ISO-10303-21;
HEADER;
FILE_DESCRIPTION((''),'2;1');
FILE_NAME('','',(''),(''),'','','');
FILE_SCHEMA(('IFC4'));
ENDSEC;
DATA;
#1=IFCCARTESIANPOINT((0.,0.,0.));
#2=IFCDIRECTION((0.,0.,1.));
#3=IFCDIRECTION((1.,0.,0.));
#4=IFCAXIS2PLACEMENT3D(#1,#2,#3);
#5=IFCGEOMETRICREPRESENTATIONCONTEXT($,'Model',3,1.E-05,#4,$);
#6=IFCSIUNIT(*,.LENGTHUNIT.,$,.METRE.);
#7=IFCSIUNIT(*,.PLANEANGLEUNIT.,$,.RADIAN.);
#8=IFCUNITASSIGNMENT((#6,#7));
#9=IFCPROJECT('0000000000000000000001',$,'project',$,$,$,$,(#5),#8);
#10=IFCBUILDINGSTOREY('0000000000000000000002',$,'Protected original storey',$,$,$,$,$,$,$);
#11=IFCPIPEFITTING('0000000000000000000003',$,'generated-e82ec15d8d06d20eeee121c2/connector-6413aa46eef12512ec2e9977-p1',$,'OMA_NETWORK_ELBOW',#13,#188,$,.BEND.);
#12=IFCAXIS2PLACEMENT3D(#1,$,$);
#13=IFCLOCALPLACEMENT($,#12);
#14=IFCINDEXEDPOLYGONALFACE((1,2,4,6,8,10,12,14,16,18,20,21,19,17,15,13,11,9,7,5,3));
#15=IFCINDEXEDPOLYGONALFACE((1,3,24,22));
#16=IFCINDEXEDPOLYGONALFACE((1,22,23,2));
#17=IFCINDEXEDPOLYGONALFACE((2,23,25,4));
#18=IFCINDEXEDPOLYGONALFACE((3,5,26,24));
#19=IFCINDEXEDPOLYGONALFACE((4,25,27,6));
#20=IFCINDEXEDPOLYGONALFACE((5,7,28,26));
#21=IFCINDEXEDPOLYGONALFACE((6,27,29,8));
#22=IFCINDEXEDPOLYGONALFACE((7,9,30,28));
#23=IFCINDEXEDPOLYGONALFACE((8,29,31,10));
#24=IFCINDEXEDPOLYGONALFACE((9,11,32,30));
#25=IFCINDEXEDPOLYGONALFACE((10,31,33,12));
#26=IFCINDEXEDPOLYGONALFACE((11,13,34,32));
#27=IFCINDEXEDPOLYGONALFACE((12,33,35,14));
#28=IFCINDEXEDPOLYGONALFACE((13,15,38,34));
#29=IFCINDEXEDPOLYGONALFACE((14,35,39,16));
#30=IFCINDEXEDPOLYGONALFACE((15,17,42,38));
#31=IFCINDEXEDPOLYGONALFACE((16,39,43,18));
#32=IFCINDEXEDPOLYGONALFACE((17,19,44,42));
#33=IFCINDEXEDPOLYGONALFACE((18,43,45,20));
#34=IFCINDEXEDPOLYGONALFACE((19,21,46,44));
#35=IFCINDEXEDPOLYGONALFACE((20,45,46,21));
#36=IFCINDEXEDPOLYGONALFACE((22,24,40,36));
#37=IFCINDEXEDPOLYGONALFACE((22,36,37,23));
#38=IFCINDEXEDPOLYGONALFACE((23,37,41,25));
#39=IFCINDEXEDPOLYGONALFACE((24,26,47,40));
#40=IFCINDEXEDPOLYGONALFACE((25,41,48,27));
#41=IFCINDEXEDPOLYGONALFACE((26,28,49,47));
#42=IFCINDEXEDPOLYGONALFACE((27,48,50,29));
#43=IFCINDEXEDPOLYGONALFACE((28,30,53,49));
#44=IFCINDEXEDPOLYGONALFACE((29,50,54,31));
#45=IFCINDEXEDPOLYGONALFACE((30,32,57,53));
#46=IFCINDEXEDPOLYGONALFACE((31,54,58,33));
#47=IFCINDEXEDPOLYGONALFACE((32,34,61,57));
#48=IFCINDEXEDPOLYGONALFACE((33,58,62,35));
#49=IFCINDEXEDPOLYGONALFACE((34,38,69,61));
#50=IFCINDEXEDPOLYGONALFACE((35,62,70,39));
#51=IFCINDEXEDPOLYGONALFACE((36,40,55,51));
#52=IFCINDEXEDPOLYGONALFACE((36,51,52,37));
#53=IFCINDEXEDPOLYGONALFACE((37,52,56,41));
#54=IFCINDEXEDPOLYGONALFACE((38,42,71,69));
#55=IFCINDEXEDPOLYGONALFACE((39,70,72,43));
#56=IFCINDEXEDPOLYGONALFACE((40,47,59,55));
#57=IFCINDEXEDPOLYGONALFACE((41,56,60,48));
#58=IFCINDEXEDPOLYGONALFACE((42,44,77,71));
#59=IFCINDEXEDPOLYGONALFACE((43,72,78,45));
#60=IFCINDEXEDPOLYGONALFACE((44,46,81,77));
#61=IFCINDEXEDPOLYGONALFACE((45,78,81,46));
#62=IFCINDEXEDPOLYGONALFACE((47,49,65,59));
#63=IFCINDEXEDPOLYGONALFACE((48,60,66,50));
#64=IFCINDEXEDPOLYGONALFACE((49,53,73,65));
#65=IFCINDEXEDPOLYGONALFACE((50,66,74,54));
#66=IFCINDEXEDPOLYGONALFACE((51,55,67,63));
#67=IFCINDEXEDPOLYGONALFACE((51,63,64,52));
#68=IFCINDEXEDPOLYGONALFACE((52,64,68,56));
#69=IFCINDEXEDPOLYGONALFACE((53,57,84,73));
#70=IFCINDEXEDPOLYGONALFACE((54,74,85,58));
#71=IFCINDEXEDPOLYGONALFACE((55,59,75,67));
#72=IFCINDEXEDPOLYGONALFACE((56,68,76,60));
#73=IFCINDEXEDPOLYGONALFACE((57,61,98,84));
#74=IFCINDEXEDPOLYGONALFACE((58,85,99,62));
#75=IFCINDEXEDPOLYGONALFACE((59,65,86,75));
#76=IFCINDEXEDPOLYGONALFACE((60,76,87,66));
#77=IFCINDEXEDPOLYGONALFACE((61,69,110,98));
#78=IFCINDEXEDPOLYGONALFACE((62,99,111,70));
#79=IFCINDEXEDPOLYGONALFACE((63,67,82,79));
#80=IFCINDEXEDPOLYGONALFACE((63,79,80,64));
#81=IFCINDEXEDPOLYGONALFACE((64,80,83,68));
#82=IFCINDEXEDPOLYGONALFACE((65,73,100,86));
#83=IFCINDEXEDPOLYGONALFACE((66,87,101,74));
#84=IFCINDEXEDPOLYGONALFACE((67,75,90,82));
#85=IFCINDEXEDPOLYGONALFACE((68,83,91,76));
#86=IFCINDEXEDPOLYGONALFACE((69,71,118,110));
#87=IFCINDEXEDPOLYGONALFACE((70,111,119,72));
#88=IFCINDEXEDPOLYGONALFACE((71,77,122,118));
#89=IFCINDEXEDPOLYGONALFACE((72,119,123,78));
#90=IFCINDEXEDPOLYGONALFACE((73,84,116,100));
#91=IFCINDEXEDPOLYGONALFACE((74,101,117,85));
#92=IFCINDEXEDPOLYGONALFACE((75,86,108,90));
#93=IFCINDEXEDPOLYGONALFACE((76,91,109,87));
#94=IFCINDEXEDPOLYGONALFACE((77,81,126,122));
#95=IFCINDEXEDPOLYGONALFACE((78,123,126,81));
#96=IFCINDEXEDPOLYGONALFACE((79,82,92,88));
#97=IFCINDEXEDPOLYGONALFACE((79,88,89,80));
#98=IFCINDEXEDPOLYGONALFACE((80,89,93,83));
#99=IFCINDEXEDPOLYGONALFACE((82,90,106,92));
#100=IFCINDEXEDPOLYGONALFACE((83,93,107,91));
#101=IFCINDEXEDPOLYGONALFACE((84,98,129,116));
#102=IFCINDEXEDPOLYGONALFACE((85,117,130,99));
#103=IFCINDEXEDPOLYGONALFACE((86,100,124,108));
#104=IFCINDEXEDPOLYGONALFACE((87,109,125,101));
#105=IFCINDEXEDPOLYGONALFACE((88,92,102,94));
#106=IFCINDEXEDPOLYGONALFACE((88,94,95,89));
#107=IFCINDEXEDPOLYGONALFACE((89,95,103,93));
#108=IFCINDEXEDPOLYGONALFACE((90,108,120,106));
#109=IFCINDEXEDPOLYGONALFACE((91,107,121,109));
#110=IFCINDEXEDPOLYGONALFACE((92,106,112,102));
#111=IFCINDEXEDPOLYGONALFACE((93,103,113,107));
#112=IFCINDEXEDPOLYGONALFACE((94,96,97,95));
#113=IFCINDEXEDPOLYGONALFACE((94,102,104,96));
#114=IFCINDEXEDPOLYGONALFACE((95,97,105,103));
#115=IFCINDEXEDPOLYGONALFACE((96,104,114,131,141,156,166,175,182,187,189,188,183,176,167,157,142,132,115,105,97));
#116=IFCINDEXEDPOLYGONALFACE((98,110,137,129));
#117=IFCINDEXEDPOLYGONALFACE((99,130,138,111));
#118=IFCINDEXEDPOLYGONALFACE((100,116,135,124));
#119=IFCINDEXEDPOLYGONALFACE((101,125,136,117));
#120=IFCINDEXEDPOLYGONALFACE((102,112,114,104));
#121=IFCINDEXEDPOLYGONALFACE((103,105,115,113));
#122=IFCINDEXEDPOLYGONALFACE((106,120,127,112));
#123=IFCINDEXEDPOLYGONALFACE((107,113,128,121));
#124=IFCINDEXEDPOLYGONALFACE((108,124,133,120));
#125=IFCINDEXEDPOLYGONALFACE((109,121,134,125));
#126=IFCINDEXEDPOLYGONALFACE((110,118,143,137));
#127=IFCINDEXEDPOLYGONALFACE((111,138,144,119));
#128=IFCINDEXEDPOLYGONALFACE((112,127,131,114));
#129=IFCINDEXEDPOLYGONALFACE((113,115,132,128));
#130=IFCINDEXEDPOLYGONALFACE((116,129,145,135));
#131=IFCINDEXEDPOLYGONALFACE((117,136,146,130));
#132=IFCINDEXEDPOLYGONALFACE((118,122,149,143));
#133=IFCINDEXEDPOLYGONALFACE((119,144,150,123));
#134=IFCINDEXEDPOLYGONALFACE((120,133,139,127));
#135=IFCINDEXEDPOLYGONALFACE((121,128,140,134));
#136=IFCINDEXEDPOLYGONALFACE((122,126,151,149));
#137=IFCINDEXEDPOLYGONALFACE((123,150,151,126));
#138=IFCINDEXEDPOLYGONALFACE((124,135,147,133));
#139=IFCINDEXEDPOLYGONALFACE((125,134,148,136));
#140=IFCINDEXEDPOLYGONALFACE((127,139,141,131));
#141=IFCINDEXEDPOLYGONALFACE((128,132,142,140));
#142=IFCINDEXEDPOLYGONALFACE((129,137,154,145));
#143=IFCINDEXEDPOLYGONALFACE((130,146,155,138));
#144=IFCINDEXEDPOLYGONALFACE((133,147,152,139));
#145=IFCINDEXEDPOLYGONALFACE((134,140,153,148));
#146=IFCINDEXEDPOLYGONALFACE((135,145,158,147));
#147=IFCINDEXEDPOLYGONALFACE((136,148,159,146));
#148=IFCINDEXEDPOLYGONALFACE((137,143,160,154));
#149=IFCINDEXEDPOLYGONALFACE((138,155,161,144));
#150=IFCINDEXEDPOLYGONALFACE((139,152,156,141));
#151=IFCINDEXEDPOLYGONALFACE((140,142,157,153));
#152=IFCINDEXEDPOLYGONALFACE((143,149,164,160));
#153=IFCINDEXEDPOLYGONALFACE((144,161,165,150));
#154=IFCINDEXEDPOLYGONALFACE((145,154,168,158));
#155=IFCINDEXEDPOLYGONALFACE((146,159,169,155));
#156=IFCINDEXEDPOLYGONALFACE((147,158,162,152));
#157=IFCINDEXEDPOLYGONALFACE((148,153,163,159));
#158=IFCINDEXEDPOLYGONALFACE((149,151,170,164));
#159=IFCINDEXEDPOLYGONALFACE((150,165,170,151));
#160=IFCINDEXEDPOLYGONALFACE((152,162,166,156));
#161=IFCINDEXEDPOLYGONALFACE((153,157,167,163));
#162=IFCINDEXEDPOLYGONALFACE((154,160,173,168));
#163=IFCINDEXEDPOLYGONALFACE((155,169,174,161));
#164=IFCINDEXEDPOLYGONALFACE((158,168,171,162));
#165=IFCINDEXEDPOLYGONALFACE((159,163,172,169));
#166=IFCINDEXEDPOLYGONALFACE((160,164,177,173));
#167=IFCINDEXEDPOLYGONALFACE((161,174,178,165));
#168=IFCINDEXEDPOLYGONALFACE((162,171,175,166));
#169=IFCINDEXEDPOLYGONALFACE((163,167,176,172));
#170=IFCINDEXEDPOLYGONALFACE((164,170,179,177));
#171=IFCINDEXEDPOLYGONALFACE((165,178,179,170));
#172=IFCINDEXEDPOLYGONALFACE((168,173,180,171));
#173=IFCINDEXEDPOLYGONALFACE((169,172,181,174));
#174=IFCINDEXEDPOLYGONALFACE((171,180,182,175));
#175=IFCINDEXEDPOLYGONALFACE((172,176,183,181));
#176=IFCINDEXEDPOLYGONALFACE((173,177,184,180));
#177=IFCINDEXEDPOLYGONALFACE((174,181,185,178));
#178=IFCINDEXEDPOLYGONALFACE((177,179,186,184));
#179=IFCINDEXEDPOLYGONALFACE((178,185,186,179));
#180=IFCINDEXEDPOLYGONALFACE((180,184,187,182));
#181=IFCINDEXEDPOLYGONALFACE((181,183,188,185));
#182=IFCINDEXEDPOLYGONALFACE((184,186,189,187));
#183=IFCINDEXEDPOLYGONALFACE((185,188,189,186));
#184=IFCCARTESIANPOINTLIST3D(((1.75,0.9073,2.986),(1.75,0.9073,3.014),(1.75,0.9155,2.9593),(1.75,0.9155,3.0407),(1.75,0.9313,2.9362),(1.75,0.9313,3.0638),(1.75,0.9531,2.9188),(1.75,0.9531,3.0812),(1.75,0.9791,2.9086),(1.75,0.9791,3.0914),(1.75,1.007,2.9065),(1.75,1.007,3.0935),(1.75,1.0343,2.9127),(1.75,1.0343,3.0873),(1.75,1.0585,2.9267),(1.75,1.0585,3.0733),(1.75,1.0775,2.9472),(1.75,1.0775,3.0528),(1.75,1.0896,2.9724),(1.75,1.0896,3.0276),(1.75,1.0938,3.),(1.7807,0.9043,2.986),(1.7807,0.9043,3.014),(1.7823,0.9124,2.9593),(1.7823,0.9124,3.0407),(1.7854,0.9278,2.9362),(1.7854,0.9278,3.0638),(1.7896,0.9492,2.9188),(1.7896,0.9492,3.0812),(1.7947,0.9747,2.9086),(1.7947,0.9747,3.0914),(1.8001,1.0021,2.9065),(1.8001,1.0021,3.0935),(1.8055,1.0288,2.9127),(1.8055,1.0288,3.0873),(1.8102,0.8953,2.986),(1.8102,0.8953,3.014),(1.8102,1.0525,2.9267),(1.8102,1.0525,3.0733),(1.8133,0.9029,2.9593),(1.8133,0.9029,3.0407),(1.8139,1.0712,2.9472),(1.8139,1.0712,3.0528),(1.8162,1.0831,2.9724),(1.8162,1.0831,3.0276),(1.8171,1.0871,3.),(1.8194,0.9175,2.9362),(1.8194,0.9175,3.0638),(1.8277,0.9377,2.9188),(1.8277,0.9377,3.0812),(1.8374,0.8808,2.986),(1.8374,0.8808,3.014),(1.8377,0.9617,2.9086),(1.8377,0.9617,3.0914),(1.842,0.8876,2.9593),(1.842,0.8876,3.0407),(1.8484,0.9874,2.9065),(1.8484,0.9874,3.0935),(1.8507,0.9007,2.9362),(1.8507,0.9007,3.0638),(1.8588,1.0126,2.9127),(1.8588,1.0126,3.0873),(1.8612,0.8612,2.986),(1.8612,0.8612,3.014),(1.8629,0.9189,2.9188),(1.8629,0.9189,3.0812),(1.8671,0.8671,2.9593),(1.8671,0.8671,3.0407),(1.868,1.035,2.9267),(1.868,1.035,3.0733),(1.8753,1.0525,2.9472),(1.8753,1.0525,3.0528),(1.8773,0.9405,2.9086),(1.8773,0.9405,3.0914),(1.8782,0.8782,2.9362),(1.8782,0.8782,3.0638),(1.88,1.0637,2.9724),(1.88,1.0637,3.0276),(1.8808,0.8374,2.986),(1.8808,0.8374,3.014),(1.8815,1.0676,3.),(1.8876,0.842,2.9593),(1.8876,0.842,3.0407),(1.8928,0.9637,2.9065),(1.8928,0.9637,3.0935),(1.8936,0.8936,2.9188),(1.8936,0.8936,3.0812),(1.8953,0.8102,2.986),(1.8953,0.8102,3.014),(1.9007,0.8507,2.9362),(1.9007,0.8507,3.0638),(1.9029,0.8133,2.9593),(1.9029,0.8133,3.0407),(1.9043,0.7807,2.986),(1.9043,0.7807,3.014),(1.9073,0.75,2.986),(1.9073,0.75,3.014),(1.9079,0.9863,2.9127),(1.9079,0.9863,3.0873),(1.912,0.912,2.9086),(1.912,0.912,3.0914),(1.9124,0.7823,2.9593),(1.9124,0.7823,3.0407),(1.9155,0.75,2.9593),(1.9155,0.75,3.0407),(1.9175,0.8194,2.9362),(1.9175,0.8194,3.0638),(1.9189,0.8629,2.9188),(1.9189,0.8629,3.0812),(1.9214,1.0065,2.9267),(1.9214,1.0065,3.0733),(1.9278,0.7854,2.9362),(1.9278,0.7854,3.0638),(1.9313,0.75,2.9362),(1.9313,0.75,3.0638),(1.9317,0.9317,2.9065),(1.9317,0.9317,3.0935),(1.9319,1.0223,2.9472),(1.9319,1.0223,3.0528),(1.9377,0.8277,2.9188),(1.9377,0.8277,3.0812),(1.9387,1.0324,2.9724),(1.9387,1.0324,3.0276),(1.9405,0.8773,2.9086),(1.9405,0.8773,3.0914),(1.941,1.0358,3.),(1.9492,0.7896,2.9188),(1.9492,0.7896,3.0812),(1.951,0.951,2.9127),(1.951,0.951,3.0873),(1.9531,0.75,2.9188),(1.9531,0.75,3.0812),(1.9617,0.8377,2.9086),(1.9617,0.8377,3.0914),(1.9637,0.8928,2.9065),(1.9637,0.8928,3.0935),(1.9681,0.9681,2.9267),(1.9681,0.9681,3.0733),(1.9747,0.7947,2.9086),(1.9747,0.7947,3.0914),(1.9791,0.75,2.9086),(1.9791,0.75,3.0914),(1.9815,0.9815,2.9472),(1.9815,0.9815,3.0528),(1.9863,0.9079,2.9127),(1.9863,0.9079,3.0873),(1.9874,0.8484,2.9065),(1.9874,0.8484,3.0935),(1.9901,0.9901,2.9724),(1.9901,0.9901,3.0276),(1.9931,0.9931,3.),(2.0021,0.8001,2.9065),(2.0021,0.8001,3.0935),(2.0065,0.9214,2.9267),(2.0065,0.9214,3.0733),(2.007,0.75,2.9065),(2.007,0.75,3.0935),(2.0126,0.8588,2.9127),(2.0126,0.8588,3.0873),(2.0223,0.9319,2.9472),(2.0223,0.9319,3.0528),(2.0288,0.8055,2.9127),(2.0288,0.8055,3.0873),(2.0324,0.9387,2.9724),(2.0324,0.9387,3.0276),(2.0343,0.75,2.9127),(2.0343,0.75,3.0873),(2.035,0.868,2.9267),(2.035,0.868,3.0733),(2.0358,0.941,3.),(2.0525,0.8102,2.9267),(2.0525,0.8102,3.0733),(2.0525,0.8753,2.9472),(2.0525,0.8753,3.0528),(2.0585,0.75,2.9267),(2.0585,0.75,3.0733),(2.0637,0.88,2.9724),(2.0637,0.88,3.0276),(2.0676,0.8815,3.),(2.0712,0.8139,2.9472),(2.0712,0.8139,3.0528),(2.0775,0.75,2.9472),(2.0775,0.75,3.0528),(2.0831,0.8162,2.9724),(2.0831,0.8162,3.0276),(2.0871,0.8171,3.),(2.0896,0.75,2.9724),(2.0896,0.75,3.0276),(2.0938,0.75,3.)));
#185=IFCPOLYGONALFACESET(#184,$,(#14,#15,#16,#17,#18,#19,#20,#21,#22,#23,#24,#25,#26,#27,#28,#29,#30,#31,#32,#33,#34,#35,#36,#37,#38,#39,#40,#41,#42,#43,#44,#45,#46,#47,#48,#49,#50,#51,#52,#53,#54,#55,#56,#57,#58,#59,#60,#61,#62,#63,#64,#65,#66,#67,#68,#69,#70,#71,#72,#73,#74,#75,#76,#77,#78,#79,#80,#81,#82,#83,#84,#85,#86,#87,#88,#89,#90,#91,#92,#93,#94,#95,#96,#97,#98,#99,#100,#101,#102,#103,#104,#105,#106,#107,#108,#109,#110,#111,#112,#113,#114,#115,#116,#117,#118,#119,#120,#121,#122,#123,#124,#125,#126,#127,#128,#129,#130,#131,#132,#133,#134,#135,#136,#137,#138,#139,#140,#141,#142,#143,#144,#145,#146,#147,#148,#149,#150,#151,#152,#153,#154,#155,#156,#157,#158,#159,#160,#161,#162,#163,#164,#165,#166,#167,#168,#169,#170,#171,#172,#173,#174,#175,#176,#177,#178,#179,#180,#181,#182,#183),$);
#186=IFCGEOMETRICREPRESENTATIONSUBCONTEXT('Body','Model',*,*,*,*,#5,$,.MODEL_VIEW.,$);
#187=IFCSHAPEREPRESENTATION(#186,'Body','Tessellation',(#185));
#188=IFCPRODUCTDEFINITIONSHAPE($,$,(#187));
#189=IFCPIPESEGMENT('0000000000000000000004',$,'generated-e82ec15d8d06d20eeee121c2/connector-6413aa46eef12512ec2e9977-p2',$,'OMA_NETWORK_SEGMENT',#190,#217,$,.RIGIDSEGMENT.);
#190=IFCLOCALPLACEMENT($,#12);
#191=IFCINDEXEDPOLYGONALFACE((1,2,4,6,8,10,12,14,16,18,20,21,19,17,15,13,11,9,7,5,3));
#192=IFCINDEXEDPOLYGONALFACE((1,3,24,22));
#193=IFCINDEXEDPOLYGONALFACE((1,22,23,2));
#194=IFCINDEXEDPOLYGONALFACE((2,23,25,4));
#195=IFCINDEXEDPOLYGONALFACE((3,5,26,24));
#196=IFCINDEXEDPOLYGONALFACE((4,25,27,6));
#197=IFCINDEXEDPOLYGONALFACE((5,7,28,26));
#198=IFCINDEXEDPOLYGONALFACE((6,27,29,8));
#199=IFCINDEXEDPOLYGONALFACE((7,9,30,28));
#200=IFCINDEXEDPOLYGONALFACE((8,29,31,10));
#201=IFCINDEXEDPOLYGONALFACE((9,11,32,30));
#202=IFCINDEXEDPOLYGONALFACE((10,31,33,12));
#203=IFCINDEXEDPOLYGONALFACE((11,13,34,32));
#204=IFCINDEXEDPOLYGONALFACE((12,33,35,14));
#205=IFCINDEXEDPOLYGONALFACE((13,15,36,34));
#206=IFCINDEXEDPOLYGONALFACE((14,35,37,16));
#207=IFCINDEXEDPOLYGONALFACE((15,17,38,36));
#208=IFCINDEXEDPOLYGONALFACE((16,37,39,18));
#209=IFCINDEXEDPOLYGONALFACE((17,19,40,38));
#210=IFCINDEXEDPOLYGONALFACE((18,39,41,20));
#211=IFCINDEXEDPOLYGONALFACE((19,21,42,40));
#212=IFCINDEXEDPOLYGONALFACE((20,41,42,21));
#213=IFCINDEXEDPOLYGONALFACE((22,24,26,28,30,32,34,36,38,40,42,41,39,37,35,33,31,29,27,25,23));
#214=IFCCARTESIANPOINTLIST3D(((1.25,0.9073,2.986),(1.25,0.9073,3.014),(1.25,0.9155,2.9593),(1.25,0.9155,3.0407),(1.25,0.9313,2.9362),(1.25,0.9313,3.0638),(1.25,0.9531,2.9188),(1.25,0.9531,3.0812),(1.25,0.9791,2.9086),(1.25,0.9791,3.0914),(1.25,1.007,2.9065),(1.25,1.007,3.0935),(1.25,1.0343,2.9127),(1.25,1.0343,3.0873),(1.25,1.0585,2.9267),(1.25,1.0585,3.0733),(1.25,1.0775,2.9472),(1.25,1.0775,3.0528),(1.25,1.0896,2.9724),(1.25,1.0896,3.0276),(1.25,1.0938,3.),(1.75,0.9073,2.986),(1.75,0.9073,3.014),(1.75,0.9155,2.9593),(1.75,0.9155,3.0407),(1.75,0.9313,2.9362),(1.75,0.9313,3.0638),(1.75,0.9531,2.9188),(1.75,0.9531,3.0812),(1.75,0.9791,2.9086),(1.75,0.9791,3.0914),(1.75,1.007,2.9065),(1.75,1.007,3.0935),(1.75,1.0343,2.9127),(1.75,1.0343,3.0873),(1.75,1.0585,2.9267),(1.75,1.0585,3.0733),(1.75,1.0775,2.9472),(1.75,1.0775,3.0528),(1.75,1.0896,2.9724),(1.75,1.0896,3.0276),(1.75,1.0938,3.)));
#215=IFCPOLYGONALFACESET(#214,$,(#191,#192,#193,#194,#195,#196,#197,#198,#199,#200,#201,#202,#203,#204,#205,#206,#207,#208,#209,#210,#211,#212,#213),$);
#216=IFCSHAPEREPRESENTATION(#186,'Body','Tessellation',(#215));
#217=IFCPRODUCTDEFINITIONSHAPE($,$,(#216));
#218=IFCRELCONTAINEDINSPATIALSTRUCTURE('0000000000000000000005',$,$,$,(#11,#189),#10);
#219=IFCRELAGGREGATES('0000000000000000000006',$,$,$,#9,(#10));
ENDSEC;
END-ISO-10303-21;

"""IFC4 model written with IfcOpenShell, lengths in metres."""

from ifc_helpers import new_model, entity, si_unit, frame, origin_with_axes, origin_2d, place, context, subcontext, project, spatial, circle, extrude, element, save


model = new_model("IFC4")

# Units and contexts
model_context = context("Model", 3, precision=1e-05, world=origin_with_axes())
body_context = subcontext(model_context, "Body", "Model", "MODEL_VIEW")
ifc_project = project(units=[si_unit("LENGTHUNIT", "METRE"), si_unit("PLANEANGLEUNIT", "RADIAN")], contexts=[model_context])

# Storey
storey = spatial("IfcBuildingStorey", under=ifc_project, Name="Protected original storey")

# Pipe fitting
pipe_fitting_1_placement = place(None, origin_with_axes())
element("IfcPipeFitting", 1, at=pipe_fitting_1_placement, inside=storey, Name="generated-e82ec15d8d06d20eeee121c2/connector-6413aa46eef12512ec2e9977-p1", ObjectType="OMA_NETWORK_ELBOW", PredefinedType="BEND", context=body_context, shape_type="SweptSolid", body=[
    entity("IfcRevolvedAreaSolid", entity("IfcCircleProfileDef", "AREA", None, entity("IfcAxis2Placement2D", entity("IfcCartesianPoint", [0.25, 0.0])), 0.0938), entity("IfcAxis2Placement3D", entity("IfcCartesianPoint", [1.75, 0.75, 3.0]), entity("IfcDirection", [0.0, 1.0, 0.0]), entity("IfcDirection", [1.0, 0.0, 0.0])), entity("IfcAxis1Placement", entity("IfcCartesianPoint", [0.0, 0.0, 0.0]), entity("IfcDirection", [0.0, -1.0, 0.0])), 1.570796),
])

# Pipe segment
pipe_segment_1_placement = place(None, origin_with_axes())
element("IfcPipeSegment", 2, at=pipe_segment_1_placement, inside=storey, Name="generated-e82ec15d8d06d20eeee121c2/connector-6413aa46eef12512ec2e9977-p2", ObjectType="OMA_NETWORK_SEGMENT", PredefinedType="RIGIDSEGMENT", context=body_context, shape_type="SweptSolid", body=[
    extrude(circle(Radius=0.0938, at=origin_2d()), frame((1.75, 1.0, 3.0), z_axis=(-1.0, 0.0, 0.0), x_axis=(0.0, 1.0, 0.0)), (0.0, 0.0, 1.0), 0.5),
])

save(model, "model.ifc")
